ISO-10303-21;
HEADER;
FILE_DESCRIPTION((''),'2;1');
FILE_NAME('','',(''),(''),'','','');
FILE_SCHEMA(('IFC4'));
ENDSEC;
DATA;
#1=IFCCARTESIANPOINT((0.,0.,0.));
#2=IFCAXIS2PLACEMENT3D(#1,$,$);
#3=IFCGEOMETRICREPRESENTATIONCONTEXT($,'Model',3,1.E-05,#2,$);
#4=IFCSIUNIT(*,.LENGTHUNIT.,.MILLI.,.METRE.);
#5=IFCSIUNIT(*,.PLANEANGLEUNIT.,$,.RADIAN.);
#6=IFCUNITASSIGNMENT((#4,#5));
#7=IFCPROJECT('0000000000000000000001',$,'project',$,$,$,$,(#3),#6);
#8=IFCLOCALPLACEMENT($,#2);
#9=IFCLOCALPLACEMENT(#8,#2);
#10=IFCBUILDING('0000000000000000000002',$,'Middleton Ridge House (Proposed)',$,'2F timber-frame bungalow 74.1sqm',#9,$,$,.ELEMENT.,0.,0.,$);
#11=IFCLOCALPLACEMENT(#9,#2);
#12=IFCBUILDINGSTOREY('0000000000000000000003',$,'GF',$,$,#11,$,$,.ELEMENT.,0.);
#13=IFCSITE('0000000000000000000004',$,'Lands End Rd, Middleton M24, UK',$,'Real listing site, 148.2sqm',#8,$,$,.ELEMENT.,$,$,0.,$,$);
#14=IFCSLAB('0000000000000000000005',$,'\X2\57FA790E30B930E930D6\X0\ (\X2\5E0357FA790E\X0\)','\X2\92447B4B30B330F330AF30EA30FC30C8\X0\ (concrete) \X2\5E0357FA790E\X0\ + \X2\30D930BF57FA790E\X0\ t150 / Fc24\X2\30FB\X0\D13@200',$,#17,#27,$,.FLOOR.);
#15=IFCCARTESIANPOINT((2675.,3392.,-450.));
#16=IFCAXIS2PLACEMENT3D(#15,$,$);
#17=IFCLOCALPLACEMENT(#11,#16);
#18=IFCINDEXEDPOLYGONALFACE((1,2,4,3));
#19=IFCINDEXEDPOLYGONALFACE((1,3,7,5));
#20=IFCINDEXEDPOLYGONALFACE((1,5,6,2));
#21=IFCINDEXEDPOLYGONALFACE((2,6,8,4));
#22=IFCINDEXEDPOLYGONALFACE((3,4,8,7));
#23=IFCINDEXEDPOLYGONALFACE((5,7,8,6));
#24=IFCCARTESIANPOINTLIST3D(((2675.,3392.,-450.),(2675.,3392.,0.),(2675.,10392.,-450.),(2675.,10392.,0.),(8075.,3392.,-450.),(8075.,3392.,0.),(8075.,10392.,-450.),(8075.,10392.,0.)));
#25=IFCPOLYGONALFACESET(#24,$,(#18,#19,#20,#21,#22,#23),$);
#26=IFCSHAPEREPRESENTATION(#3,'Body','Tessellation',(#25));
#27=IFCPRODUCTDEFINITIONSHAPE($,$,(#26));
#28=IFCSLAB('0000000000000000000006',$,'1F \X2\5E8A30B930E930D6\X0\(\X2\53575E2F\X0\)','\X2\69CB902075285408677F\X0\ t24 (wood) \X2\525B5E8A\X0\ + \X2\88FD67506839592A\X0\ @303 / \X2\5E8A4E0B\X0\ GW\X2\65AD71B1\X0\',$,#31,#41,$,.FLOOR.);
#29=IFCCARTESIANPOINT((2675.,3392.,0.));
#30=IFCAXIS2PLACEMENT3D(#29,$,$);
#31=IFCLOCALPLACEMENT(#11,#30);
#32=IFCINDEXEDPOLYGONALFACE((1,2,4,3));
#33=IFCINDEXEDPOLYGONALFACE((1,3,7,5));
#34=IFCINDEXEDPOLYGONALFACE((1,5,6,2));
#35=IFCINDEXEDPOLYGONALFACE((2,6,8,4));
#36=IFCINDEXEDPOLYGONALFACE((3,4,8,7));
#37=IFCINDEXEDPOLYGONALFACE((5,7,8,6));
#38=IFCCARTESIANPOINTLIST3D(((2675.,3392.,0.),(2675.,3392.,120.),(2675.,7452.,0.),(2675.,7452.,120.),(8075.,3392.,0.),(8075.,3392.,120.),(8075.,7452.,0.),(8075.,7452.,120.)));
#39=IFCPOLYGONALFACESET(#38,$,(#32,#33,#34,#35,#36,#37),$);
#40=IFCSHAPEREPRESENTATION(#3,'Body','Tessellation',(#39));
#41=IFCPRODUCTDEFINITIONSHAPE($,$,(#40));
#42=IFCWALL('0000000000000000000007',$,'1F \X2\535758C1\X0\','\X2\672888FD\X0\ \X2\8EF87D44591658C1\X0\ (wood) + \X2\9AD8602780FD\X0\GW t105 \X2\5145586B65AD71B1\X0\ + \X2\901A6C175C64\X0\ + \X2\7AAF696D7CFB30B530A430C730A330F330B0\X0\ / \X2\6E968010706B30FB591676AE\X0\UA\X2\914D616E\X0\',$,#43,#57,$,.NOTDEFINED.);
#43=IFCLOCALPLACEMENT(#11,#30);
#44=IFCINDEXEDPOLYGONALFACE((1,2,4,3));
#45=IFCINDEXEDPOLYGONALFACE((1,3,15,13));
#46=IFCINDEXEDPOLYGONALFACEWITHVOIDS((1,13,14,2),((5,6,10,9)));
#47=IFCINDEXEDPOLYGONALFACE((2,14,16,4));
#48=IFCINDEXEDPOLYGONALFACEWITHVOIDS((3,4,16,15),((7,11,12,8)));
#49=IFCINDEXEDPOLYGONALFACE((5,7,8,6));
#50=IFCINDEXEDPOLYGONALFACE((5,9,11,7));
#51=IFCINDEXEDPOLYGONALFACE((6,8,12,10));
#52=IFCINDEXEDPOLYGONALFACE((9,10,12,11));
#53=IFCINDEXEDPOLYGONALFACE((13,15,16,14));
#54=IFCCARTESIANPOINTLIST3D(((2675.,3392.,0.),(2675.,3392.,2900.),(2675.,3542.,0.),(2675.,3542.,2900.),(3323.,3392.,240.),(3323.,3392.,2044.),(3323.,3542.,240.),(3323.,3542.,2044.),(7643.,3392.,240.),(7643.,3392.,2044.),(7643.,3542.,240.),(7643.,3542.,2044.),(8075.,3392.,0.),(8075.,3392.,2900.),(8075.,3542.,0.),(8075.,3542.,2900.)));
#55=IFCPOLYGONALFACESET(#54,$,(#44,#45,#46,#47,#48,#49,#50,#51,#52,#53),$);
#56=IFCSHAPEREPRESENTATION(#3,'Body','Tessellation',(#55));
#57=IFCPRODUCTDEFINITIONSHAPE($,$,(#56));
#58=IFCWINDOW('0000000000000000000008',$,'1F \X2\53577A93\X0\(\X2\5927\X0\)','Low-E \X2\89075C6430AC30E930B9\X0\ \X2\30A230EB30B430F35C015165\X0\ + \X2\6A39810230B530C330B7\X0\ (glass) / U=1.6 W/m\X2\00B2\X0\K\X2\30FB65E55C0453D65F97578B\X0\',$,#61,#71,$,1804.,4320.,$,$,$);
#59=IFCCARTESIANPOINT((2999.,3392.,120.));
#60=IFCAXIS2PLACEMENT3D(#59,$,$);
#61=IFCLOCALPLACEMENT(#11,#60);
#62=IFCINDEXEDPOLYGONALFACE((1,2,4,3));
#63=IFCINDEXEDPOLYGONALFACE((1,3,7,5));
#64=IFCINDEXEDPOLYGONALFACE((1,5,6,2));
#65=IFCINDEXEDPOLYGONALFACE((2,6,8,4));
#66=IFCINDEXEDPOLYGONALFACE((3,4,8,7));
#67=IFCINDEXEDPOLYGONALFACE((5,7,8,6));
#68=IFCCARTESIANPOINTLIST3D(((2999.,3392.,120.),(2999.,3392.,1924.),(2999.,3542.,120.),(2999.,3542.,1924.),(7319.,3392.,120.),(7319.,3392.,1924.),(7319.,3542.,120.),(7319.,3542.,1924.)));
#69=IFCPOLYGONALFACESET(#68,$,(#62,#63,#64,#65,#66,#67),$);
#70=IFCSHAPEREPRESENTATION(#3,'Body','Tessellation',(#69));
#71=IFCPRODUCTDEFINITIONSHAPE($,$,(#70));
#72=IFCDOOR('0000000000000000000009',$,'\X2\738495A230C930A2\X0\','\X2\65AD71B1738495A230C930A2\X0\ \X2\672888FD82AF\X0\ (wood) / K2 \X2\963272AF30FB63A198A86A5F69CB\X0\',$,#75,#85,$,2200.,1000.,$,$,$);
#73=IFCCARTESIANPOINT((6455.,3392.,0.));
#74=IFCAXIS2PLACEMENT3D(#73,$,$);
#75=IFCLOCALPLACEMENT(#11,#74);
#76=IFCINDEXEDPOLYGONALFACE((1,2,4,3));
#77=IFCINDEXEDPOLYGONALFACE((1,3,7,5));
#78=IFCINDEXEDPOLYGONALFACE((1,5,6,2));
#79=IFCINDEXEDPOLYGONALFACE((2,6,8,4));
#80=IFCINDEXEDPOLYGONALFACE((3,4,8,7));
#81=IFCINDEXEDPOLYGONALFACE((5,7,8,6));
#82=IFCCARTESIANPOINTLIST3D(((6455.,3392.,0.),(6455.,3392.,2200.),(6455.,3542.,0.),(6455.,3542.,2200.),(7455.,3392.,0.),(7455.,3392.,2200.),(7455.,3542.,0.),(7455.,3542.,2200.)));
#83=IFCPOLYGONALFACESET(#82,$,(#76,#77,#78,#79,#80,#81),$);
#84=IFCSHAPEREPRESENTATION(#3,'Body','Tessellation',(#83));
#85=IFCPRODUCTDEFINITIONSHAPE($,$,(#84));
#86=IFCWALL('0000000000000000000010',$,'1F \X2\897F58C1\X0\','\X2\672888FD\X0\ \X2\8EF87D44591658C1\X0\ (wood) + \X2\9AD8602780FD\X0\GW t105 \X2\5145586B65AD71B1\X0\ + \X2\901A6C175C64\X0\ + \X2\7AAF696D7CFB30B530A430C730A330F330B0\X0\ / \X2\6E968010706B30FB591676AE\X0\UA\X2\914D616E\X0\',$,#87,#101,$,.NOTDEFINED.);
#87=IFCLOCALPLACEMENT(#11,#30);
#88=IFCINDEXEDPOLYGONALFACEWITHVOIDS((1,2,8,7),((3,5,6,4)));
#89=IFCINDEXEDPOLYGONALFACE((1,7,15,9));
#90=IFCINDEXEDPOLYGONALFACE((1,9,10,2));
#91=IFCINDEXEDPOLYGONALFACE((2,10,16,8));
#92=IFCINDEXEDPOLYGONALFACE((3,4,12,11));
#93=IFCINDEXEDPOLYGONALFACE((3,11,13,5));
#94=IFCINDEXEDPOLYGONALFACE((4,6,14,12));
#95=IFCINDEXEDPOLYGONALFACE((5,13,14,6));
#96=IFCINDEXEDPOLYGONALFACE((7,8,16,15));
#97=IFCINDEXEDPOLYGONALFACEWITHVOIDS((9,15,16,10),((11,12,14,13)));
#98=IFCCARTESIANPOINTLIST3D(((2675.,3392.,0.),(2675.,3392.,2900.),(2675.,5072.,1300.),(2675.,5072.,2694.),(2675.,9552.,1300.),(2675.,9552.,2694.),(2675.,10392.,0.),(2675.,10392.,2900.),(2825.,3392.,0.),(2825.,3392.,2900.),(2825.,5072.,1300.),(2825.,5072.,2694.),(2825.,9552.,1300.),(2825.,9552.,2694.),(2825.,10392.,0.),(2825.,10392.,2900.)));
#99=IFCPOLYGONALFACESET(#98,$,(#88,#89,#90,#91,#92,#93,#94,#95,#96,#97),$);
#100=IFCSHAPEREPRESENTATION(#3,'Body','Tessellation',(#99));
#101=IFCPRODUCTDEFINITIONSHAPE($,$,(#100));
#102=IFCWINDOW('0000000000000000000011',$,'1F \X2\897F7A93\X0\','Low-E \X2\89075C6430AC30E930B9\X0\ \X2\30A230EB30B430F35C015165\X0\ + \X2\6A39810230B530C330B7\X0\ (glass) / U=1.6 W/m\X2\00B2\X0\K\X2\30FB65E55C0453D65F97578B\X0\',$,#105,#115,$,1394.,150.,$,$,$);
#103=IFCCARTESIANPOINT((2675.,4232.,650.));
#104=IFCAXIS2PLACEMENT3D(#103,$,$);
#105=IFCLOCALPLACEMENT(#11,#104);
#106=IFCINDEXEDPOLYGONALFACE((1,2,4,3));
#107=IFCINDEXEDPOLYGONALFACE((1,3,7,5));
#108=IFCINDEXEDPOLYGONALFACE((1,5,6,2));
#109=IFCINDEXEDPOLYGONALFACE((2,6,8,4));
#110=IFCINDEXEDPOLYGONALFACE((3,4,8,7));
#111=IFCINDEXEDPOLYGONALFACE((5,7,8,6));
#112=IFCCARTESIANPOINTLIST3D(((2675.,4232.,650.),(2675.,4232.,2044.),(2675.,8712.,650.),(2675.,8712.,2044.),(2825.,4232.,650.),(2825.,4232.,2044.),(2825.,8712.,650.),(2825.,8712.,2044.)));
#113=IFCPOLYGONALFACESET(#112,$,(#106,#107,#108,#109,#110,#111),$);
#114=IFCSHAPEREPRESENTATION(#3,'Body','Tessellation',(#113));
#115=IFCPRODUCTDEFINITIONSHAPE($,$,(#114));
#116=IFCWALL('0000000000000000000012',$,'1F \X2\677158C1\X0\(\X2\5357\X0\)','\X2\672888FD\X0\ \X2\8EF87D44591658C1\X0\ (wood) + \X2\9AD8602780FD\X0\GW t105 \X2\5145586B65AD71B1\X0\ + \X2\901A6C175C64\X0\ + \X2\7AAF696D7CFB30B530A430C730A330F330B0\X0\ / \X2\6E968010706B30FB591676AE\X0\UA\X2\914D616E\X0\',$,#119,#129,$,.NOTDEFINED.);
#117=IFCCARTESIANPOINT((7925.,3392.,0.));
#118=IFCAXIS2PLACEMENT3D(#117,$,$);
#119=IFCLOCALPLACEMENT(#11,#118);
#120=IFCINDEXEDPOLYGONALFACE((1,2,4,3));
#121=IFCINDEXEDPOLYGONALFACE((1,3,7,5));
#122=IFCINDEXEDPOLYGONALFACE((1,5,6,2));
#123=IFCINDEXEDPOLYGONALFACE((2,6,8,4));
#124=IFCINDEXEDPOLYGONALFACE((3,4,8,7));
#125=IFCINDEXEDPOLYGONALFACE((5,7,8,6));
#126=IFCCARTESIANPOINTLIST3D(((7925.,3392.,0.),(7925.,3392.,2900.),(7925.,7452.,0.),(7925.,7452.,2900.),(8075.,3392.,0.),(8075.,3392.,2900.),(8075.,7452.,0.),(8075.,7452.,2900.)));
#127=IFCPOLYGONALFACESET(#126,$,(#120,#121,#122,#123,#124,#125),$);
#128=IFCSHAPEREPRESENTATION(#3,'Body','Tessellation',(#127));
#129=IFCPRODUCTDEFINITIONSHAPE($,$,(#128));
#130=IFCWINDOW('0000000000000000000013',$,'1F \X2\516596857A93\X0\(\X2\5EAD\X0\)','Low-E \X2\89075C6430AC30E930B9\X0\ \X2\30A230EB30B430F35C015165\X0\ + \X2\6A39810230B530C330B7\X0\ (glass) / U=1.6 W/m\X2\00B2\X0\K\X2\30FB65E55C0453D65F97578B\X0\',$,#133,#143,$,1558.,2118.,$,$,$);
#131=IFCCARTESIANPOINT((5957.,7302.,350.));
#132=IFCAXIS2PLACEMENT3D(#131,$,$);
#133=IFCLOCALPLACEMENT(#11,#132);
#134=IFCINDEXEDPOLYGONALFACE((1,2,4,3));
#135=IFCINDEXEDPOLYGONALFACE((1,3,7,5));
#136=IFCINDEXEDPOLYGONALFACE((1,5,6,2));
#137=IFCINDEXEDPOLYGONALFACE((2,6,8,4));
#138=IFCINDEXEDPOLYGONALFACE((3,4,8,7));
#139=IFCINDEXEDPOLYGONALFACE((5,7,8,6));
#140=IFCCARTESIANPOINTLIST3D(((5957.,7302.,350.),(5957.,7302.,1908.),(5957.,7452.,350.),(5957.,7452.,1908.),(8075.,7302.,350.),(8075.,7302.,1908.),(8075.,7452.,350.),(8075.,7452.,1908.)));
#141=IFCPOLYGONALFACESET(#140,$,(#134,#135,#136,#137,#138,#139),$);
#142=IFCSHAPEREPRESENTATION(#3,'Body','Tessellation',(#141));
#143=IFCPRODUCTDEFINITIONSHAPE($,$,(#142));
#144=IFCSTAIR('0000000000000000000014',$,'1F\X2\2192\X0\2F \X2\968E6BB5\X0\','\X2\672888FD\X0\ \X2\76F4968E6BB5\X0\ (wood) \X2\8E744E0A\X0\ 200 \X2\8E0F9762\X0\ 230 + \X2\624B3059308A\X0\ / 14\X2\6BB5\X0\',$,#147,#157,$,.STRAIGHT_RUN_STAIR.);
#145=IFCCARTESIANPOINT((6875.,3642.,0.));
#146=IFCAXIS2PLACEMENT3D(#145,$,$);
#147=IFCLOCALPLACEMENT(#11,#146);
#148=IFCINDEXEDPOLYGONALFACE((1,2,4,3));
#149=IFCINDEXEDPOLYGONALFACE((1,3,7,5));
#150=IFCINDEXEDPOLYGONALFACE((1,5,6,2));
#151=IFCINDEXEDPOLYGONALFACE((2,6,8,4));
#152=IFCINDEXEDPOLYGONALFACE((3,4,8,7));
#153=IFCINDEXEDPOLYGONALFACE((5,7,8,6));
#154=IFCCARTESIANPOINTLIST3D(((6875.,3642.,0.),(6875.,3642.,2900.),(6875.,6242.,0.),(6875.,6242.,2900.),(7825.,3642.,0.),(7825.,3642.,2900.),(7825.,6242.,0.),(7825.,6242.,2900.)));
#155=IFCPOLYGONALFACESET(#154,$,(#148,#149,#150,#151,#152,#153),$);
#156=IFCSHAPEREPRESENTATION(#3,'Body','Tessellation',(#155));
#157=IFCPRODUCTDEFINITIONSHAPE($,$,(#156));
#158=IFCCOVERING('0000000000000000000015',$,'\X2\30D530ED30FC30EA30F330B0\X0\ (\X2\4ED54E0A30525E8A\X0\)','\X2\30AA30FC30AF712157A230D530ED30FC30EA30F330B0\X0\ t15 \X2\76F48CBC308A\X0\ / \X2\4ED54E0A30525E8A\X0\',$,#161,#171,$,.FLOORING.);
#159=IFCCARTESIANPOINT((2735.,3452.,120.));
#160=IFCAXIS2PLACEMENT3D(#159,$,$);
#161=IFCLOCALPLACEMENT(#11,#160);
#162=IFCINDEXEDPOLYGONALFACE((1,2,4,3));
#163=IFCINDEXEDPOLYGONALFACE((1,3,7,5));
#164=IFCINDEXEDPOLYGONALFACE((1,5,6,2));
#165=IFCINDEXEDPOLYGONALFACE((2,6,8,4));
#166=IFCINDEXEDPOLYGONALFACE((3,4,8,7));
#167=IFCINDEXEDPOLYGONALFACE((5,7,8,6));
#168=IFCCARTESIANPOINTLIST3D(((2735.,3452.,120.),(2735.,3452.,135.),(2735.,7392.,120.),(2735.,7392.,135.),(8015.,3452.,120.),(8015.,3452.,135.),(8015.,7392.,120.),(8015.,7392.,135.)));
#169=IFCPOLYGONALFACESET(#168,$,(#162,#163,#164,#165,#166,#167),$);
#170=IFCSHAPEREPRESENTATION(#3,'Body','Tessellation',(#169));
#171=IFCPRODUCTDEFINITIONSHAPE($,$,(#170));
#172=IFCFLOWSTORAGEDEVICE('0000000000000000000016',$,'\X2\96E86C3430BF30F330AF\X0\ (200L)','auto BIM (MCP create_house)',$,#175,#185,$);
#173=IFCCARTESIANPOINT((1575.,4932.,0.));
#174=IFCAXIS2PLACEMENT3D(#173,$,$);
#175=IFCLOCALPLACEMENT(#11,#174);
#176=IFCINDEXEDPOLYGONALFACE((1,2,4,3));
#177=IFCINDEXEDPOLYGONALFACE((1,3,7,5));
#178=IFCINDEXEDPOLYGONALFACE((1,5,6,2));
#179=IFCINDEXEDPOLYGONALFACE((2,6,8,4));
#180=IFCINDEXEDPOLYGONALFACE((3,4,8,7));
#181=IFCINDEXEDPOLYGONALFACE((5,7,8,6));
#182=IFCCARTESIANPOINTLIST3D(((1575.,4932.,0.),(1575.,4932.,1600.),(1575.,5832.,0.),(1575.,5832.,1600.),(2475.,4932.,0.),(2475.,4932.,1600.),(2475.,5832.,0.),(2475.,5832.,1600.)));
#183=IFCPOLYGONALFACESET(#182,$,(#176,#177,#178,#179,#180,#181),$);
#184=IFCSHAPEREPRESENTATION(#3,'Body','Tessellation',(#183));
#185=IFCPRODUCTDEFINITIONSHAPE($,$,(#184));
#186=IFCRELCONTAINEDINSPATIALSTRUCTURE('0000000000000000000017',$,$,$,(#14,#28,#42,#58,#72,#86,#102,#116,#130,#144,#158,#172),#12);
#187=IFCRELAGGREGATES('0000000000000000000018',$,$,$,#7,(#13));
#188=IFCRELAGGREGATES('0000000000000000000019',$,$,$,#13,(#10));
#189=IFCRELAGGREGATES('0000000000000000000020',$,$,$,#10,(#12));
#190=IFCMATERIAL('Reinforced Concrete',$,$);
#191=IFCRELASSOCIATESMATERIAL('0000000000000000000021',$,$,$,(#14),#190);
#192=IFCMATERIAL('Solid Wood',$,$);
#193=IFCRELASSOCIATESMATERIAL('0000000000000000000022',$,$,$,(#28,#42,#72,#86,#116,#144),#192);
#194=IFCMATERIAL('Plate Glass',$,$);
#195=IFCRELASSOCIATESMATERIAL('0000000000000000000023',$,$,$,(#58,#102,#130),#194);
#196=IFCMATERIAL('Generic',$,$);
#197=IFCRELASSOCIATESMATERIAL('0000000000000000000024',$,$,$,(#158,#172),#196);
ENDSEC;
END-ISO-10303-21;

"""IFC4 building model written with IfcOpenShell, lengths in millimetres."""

from ifc_helpers import new_model, si_unit, frame, frame_2d, origin, place, context, project, spatial, rectangle, extrude, material, element, fill, save


model = new_model("IFC4")

# Units and contexts
model_context = context("Model", 3, precision=1e-05, world=origin())
ifc_project = project(units=[si_unit("LENGTHUNIT", "METRE", prefix="MILLI"), si_unit("PLANEANGLEUNIT", "RADIAN")], contexts=[model_context])

# Site, building, storey
site_placement = place(None, origin())
site = spatial("IfcSite", under=ifc_project, at=site_placement, Name="Lands End Rd, Middleton M24, UK", ObjectType="Real listing site, 148.2sqm", CompositionType="ELEMENT", RefElevation=0.0)
building_placement = place(site_placement, origin())
building = spatial("IfcBuilding", under=site, at=building_placement, Name="Middleton Ridge House (Proposed)", ObjectType="2F timber-frame bungalow 74.1sqm", CompositionType="ELEMENT", ElevationOfRefHeight=0.0, ElevationOfTerrain=0.0)
storey_placement = place(building_placement, origin())
storey = spatial("IfcBuildingStorey", under=building, at=storey_placement, Name="GF", CompositionType="ELEMENT", Elevation=0.0)

# Slabs
ifc_material_1 = material(Name="Reinforced Concrete")
slab_1_placement = place(storey_placement, frame((2675.0, 3392.0, -450.0)))
element("IfcSlab", 1, at=slab_1_placement, inside=storey, material=ifc_material_1, Name="基礎スラブ (布基礎)", Description="鉄筋コンクリート (concrete) 布基礎 + ベタ基礎 t150 / Fc24・D13@200", PredefinedType="FLOOR", context=model_context, shape_type="SweptSolid", body=[
    extrude(rectangle(XDim=5400.0, YDim=7000.0, at=frame_2d((2700.0, 3500.0))), frame((2675.0, 3392.0, -450.0)), (0.0, 0.0, 1.0), 450.0),
])
ifc_material_2 = material(Name="Solid Wood")
slab_2_placement = place(storey_placement, frame((2675.0, 3392.0, 0.0)))
element("IfcSlab", 2, at=slab_2_placement, inside=storey, material=ifc_material_2, Name="1F 床スラブ(南帯)", Description="構造用合板 t24 (wood) 剛床 + 製材根太 @303 / 床下 GW断熱", PredefinedType="FLOOR", context=model_context, shape_type="SweptSolid", body=[
    extrude(rectangle(XDim=5400.0, YDim=4060.0, at=frame_2d((2700.0, 2030.0))), frame((2675.0, 3392.0, 0.0)), (0.0, 0.0, 1.0), 120.0),
])

# Wall, openings, window, door
wall_1_placement = place(storey_placement, frame((2675.0, 3392.0, 0.0)))
wall_1 = element("IfcWall", 3, at=wall_1_placement, inside=storey, material=ifc_material_2, Name="1F 南壁", Description="木製 軸組外壁 (wood) + 高性能GW t105 充填断熱 + 通気層 + 窯業系サイディング / 準耐火・外皮UA配慮", PredefinedType="NOTDEFINED", context=model_context, shape_type="SweptSolid", body=[
    extrude(rectangle(XDim=5400.0, YDim=150.0, at=frame_2d((2700.0, 75.0))), frame((2675.0, 3392.0, 0.0)), (0.0, 0.0, 1.0), 2900.0),
])
opening_1_placement = place(storey_placement, frame((2999.0, 3392.0, 120.0)))
opening_1 = element("IfcOpeningElement", 4, at=opening_1_placement, cuts=wall_1, PredefinedType="NOTDEFINED", context=model_context, shape_type="SweptSolid", body=[
    extrude(rectangle(XDim=4320.0, YDim=150.0, at=frame_2d((2160.0, 75.0))), frame((2999.0, 3392.0, 120.0)), (0.0, 0.0, 1.0), 1804.0),
])
opening_2_placement = place(storey_placement, frame((6455.0, 3392.0, 0.0)))
opening_2 = element("IfcOpeningElement", 5, at=opening_2_placement, cuts=wall_1, PredefinedType="NOTDEFINED", context=model_context, shape_type="SweptSolid", body=[
    extrude(rectangle(XDim=1000.0, YDim=150.0, at=frame_2d((500.0, 75.0))), frame((6455.0, 3392.0, 0.0)), (0.0, 0.0, 1.0), 2200.0),
])
ifc_material_3 = material(Name="Plate Glass")
window_1_placement = place(storey_placement, frame((2999.0, 3392.0, 120.0)))
window_1 = element("IfcWindow", 6, at=window_1_placement, inside=storey, material=ifc_material_3, Name="1F 南窓(大)", Description="Low-E 複層ガラス アルゴン封入 + 樹脂サッシ (glass) / U=1.6 W/m²K・日射取得型", OverallHeight=1804.0, OverallWidth=4320.0, context=model_context, shape_type="SweptSolid", body=[
    extrude(rectangle(XDim=4320.0, YDim=150.0, at=frame_2d((2160.0, 75.0))), frame((2999.0, 3392.0, 120.0)), (0.0, 0.0, 1.0), 1804.0),
])
fill(opening_1, window_1)
door_1_placement = place(storey_placement, frame((6455.0, 3392.0, 0.0)))
door_1 = element("IfcDoor", 7, at=door_1_placement, inside=storey, material=ifc_material_2, Name="玄関ドア", Description="断熱玄関ドア 木製芯 (wood) / K2 防犯・採風機構", OverallHeight=2200.0, OverallWidth=1000.0, context=model_context, shape_type="SweptSolid", body=[
    extrude(rectangle(XDim=1000.0, YDim=150.0, at=frame_2d((500.0, 75.0))), frame((6455.0, 3392.0, 0.0)), (0.0, 0.0, 1.0), 2200.0),
])
fill(opening_2, door_1)

# Walls, openings, windows
wall_2_placement = place(storey_placement, frame((2675.0, 3392.0, 0.0)))
wall_2 = element("IfcWall", 8, at=wall_2_placement, inside=storey, material=ifc_material_2, Name="1F 西壁", Description="木製 軸組外壁 (wood) + 高性能GW t105 充填断熱 + 通気層 + 窯業系サイディング / 準耐火・外皮UA配慮", PredefinedType="NOTDEFINED", context=model_context, shape_type="SweptSolid", body=[
    extrude(rectangle(XDim=150.0, YDim=7000.0, at=frame_2d((75.0, 3500.0))), frame((2675.0, 3392.0, 0.0)), (0.0, 0.0, 1.0), 2900.0),
])
opening_3_placement = place(storey_placement, frame((2675.0, 4232.0, 650.0)))
opening_3 = element("IfcOpeningElement", 9, at=opening_3_placement, cuts=wall_2, PredefinedType="NOTDEFINED", context=model_context, shape_type="SweptSolid", body=[
    extrude(rectangle(XDim=150.0, YDim=4480.0, at=frame_2d((75.0, 2240.0))), frame((2675.0, 4232.0, 650.0)), (0.0, 0.0, 1.0), 1394.0),
])
window_2_placement = place(storey_placement, frame((2675.0, 4232.0, 650.0)))
window_2 = element("IfcWindow", 10, at=window_2_placement, inside=storey, material=ifc_material_3, Name="1F 西窓", Description="Low-E 複層ガラス アルゴン封入 + 樹脂サッシ (glass) / U=1.6 W/m²K・日射取得型", OverallHeight=1394.0, OverallWidth=150.0, context=model_context, shape_type="SweptSolid", body=[
    extrude(rectangle(XDim=150.0, YDim=4480.0, at=frame_2d((75.0, 2240.0))), frame((2675.0, 4232.0, 650.0)), (0.0, 0.0, 1.0), 1394.0),
])
fill(opening_3, window_2)
wall_3_placement = place(storey_placement, frame((7925.0, 3392.0, 0.0)))
wall_3 = element("IfcWall", 11, at=wall_3_placement, inside=storey, material=ifc_material_2, Name="1F 東壁(南)", Description="木製 軸組外壁 (wood) + 高性能GW t105 充填断熱 + 通気層 + 窯業系サイディング / 準耐火・外皮UA配慮", PredefinedType="NOTDEFINED", context=model_context, shape_type="SweptSolid", body=[
    extrude(rectangle(XDim=150.0, YDim=4060.0, at=frame_2d((75.0, 2030.0))), frame((7925.0, 3392.0, 0.0)), (0.0, 0.0, 1.0), 2900.0),
])
opening_4_placement = place(storey_placement, frame((5957.0, 7302.0, 350.0)))
opening_4 = element("IfcOpeningElement", 12, at=opening_4_placement, cuts=wall_3, PredefinedType="NOTDEFINED", context=model_context, shape_type="SweptSolid", body=[
    extrude(rectangle(XDim=2118.0, YDim=150.0, at=frame_2d((1059.0, 75.0))), frame((5957.0, 7302.0, 350.0)), (0.0, 0.0, 1.0), 1558.0),
])
window_3_placement = place(storey_placement, frame((5957.0, 7302.0, 350.0)))
window_3 = element("IfcWindow", 13, at=window_3_placement, inside=storey, material=ifc_material_3, Name="1F 入隅窓(庭)", Description="Low-E 複層ガラス アルゴン封入 + 樹脂サッシ (glass) / U=1.6 W/m²K・日射取得型", OverallHeight=1558.0, OverallWidth=2118.0, context=model_context, shape_type="SweptSolid", body=[
    extrude(rectangle(XDim=2118.0, YDim=150.0, at=frame_2d((1059.0, 75.0))), frame((5957.0, 7302.0, 350.0)), (0.0, 0.0, 1.0), 1558.0),
])
fill(opening_4, window_3)

# Stair
stair_placement = place(storey_placement, frame((6875.0, 3642.0, 0.0)))
element("IfcStair", 14, at=stair_placement, inside=storey, material=ifc_material_2, Name="1F→2F 階段", Description="木製 直階段 (wood) 蹴上 200 踏面 230 + 手すり / 14段", PredefinedType="STRAIGHT_RUN_STAIR", context=model_context, shape_type="SweptSolid", body=[
    extrude(rectangle(XDim=950.0, YDim=2600.0, at=frame_2d((475.0, 1300.0))), frame((6875.0, 3642.0, 0.0)), (0.0, 0.0, 1.0), 2900.0),
])

# Covering
ifc_material_4 = material(Name="Generic")
covering_placement = place(storey_placement, frame((2735.0, 3452.0, 120.0)))
element("IfcCovering", 15, at=covering_placement, inside=storey, material=ifc_material_4, Name="フローリング (仕上げ床)", Description="オーク無垢フローリング t15 直貼り / 仕上げ床", PredefinedType="FLOORING", context=model_context, shape_type="SweptSolid", body=[
    extrude(rectangle(XDim=5280.0, YDim=3940.0, at=frame_2d((2640.0, 1970.0))), frame((2735.0, 3452.0, 120.0)), (0.0, 0.0, 1.0), 15.0),
])

# Flow storage device
flow_storage_device_placement = place(storey_placement, frame((1575.0, 4932.0, 0.0)))
element("IfcFlowStorageDevice", 16, at=flow_storage_device_placement, inside=storey, material=ifc_material_4, Name="雨水タンク (200L)", Description="auto BIM (MCP create_house)", context=model_context, shape_type="SweptSolid", body=[
    extrude(rectangle(XDim=900.0, YDim=900.0, at=frame_2d((450.0, 450.0))), frame((1575.0, 4932.0, 0.0)), (0.0, 0.0, 1.0), 1600.0),
])

save(model, "model.ifc")
